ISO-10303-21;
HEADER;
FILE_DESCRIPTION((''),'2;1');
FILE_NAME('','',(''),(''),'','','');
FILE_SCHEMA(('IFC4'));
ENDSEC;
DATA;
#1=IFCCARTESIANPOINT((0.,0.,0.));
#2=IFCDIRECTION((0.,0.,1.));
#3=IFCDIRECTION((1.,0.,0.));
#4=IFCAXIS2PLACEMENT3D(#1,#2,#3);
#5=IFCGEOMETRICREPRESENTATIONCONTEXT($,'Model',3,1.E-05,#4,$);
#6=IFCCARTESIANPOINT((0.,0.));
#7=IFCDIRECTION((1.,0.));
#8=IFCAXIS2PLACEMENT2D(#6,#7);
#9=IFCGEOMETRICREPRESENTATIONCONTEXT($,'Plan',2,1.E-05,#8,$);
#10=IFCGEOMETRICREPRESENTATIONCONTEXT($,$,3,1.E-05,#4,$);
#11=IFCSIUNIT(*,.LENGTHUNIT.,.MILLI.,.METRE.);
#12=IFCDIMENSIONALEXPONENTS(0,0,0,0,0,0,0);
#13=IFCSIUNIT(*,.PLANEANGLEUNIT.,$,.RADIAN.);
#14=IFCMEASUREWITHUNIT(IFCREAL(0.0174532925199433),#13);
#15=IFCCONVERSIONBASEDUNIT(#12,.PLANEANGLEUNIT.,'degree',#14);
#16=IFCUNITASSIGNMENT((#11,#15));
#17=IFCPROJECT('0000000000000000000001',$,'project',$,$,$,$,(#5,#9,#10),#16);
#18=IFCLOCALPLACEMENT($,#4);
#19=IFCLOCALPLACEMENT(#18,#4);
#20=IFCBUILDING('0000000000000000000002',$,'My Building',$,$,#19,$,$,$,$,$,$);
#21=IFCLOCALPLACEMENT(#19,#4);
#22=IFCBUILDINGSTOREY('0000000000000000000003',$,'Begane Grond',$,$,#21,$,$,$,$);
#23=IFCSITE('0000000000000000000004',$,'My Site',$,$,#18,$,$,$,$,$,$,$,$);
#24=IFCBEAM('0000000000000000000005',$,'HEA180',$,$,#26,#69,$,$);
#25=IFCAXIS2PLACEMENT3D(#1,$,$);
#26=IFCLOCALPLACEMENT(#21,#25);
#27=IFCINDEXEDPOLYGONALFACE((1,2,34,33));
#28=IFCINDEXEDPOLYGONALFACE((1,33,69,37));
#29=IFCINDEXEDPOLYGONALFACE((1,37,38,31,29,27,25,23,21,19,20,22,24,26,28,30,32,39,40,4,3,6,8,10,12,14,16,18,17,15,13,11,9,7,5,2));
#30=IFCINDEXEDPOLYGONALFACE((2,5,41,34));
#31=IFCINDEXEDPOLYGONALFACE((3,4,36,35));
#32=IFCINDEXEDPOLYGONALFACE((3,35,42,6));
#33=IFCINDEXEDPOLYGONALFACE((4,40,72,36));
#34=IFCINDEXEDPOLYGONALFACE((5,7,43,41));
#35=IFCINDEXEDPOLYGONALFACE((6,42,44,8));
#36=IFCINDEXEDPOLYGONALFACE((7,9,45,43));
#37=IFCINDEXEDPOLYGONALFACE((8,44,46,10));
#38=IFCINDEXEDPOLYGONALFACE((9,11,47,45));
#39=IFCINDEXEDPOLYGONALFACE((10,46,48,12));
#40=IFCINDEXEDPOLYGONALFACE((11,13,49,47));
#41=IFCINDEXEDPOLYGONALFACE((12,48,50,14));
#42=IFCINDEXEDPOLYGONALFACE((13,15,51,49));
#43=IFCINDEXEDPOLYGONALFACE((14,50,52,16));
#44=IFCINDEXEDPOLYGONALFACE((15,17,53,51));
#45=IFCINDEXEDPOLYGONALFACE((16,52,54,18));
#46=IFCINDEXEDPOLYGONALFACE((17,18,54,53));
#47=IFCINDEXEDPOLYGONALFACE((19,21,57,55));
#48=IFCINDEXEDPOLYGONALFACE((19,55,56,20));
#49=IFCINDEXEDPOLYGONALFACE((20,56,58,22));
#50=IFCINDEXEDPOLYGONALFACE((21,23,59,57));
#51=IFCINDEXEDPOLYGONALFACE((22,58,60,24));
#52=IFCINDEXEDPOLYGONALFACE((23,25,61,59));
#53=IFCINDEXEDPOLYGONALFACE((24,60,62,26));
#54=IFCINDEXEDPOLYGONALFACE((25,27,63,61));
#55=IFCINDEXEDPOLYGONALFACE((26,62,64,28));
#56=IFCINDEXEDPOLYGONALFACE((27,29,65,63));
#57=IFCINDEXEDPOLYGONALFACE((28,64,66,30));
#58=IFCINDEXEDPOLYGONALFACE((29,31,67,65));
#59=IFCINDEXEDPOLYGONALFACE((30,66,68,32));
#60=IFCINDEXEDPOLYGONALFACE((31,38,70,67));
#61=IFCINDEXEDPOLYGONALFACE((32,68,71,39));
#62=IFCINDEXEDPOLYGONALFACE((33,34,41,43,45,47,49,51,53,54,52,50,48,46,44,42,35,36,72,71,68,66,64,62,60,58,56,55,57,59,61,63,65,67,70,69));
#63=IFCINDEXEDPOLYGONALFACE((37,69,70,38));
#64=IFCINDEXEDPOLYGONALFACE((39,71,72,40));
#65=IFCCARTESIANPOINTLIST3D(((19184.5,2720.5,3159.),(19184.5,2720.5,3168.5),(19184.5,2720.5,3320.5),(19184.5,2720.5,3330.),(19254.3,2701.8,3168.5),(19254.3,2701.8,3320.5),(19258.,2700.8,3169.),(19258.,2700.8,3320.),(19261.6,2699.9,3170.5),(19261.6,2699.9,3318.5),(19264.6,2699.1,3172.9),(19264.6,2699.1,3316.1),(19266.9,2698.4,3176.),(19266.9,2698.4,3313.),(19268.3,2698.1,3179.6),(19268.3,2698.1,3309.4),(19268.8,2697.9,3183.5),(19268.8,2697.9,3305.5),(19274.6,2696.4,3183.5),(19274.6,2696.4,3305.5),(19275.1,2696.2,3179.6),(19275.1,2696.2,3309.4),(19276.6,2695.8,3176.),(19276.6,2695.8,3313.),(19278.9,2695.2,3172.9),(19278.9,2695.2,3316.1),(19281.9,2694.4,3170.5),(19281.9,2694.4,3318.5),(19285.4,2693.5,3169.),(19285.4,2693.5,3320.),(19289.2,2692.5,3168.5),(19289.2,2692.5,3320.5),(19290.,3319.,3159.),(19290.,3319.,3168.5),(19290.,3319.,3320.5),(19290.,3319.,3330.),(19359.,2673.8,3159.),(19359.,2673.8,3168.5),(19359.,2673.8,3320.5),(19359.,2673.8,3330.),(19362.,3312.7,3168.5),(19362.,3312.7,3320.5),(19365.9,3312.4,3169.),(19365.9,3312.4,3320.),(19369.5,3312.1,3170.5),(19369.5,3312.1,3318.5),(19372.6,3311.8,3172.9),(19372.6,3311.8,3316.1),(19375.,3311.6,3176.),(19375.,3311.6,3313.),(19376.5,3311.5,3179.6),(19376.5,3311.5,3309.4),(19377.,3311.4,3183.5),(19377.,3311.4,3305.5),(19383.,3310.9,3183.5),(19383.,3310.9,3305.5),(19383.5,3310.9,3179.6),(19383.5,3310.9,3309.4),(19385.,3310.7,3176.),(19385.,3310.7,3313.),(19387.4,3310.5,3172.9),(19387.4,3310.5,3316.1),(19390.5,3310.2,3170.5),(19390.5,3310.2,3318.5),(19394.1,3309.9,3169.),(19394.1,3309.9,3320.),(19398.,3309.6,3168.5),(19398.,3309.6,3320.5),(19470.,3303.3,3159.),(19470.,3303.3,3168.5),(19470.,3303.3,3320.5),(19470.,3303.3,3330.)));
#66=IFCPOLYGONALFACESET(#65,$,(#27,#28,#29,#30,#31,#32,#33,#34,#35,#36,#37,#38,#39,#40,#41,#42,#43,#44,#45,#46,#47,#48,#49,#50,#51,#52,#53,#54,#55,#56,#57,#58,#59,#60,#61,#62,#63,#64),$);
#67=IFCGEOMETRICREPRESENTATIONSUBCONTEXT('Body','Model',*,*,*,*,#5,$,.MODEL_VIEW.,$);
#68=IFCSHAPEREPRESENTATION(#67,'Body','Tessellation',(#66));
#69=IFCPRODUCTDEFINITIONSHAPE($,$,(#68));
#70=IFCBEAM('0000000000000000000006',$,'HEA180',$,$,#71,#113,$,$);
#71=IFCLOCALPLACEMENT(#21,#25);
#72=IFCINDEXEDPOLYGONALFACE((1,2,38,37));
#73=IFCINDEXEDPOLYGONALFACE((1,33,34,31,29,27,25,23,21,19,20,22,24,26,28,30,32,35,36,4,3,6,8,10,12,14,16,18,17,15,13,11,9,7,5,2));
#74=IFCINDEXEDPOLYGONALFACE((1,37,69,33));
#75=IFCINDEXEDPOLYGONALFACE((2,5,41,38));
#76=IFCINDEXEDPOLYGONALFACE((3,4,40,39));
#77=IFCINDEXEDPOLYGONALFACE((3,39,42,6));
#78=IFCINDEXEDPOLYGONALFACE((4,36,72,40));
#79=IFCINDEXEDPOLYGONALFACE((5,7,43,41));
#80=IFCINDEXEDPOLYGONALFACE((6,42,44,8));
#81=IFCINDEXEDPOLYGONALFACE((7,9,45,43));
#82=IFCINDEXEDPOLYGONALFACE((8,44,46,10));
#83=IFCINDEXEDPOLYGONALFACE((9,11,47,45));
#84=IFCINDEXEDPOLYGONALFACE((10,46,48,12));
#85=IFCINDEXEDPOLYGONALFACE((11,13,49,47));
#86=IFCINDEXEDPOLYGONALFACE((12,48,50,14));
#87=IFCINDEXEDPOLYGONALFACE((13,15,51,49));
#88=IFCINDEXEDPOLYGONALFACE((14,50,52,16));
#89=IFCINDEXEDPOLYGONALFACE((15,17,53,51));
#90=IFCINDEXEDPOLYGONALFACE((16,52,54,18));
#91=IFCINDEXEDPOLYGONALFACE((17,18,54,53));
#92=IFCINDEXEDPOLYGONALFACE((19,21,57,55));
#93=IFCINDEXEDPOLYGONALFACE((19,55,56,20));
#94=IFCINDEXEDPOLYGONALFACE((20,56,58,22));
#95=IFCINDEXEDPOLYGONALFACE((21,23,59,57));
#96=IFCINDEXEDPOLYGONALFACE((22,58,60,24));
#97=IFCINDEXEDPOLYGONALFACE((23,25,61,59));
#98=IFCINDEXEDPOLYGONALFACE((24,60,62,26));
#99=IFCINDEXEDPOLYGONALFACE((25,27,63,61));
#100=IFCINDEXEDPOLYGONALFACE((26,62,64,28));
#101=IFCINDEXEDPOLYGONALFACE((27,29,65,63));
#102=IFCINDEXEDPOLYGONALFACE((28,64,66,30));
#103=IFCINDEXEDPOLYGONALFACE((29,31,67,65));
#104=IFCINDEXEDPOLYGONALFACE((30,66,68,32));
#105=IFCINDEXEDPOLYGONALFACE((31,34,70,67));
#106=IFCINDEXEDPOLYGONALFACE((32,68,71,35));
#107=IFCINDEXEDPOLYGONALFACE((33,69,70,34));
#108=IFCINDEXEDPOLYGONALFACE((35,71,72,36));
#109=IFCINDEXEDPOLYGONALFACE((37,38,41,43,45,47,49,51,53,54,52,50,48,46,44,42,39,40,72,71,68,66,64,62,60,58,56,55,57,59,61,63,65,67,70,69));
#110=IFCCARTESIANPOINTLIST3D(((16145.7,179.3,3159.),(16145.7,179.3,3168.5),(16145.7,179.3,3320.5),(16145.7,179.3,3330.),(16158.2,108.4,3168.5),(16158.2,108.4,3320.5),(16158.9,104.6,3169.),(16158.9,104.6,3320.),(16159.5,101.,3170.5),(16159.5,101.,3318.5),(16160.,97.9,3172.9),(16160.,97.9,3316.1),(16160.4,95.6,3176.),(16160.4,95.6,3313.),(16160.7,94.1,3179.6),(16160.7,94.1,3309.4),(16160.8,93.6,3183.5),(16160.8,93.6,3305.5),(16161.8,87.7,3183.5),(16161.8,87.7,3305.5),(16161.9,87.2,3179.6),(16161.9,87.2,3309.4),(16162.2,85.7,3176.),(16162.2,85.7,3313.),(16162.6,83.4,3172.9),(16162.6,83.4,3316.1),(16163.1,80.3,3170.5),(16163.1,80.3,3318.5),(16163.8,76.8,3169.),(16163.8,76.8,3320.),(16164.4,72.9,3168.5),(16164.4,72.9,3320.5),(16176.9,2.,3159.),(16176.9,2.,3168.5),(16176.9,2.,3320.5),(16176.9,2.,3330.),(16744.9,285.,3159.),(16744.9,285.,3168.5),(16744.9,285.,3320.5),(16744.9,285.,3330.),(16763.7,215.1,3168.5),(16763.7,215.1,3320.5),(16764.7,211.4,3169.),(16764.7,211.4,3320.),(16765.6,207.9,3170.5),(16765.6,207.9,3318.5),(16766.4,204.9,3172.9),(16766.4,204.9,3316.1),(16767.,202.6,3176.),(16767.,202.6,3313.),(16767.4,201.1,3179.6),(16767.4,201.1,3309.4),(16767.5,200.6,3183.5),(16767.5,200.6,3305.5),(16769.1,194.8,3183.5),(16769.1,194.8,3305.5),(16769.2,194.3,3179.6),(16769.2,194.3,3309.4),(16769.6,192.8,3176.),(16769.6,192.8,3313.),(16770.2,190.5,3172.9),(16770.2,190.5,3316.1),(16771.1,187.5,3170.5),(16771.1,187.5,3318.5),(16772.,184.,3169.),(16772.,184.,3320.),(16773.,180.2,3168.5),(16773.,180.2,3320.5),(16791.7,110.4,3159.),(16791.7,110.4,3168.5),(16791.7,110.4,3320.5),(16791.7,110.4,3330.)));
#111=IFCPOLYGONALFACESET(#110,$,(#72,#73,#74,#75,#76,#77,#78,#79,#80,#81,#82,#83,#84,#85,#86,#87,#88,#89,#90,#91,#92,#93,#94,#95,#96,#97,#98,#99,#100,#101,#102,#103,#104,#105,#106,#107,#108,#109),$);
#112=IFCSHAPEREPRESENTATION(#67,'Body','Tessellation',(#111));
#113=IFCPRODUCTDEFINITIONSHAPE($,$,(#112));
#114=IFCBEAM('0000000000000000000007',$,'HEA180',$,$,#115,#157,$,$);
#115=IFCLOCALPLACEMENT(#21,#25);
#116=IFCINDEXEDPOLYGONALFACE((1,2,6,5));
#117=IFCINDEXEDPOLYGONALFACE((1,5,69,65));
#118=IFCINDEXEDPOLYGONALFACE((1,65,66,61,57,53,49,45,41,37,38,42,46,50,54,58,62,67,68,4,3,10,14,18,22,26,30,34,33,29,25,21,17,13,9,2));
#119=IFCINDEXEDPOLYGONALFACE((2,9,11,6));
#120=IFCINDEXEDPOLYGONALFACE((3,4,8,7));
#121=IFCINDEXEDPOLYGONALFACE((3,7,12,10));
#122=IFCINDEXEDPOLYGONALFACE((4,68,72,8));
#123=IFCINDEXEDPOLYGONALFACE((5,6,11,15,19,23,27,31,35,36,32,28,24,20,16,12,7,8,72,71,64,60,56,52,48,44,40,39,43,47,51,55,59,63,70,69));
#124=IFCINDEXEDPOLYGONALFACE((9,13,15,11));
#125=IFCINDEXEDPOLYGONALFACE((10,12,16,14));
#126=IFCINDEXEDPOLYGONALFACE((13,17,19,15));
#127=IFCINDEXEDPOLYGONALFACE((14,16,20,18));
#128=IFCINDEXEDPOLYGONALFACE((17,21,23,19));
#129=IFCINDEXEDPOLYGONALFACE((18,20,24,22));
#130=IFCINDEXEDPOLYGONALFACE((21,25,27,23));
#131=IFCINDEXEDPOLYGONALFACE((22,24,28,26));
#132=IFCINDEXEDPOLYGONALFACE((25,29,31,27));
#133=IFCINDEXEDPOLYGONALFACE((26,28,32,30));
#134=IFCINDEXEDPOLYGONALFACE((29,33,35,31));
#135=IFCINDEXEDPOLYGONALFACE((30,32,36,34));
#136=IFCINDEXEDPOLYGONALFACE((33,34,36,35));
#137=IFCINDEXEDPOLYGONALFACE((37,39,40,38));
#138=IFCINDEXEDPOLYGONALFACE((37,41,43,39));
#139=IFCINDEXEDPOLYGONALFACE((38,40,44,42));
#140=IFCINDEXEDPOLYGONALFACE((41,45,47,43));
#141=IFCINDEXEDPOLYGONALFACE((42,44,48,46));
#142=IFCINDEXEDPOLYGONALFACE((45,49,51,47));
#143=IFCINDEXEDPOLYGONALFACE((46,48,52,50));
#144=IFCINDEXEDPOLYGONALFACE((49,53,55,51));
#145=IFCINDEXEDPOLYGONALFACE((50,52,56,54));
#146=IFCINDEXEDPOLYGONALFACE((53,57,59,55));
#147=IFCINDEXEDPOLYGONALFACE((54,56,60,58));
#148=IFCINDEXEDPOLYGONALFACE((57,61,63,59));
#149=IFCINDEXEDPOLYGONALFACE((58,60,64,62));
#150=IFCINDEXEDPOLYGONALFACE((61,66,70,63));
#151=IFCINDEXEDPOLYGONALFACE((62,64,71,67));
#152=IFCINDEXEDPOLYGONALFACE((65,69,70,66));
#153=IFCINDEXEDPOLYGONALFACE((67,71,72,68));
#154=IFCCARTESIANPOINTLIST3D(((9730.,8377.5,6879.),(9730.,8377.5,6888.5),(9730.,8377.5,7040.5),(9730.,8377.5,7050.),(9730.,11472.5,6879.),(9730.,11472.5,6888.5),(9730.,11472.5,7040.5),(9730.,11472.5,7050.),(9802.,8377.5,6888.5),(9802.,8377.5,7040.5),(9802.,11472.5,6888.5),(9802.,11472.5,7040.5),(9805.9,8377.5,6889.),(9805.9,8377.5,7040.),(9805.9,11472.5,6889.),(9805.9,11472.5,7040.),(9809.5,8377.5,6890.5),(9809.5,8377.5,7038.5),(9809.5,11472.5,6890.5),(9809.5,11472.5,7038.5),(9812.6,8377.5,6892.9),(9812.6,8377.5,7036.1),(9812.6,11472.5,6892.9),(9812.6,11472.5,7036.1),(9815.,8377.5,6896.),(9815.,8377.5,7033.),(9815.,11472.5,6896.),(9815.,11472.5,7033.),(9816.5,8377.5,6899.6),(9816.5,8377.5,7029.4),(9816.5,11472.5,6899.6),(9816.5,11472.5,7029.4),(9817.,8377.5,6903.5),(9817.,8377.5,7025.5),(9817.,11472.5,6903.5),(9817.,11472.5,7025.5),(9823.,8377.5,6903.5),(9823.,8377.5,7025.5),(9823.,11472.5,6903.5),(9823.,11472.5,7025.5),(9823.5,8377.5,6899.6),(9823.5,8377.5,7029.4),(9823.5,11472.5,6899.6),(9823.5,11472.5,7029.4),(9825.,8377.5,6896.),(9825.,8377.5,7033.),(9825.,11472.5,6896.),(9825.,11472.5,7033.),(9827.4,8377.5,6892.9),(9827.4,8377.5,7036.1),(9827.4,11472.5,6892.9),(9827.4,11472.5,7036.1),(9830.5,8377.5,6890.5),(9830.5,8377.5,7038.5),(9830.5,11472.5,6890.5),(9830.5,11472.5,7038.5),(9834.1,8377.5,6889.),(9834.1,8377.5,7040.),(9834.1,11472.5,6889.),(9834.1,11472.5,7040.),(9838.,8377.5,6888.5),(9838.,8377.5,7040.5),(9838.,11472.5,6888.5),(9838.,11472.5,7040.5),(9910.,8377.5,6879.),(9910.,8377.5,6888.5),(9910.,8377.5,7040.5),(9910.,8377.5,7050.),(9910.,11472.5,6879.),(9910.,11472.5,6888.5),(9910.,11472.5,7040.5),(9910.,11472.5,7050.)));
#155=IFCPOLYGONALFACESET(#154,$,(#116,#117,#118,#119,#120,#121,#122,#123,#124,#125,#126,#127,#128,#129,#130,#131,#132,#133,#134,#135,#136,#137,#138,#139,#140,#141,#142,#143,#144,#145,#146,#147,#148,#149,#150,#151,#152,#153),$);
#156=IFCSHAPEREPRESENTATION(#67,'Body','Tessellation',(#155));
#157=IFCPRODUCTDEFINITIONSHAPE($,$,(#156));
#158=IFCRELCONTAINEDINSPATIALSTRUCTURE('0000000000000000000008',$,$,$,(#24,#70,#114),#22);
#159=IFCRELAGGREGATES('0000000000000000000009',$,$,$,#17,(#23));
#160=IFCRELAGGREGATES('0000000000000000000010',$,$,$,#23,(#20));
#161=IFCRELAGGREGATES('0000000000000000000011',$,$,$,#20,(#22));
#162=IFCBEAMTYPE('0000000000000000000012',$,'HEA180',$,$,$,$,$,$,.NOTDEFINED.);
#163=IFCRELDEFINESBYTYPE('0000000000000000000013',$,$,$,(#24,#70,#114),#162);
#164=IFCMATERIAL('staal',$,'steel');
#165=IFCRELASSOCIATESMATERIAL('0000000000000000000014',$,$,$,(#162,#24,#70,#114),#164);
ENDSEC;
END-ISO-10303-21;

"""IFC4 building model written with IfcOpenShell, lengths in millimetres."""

from ifc_helpers import new_model, entity, si_unit, converted_unit, frame, origin_with_axes, origin_2d_with_axis, place, context, subcontext, project, spatial, i_section, extrude, clip, halfspace, material, material_profile, profile_set, profile_usage, type_object, element, save


model = new_model("IFC4")

# Units and contexts
model_context = context("Model", 3, precision=1e-05, world=origin_with_axes())
plan_context = context("Plan", 2, precision=1e-05, world=origin_2d_with_axis())
context_of_model = context(None, 3, precision=1e-05, world=origin_with_axes())
body_context = subcontext(model_context, "Body", "Model", "MODEL_VIEW")
ifc_project = project(units=[si_unit("LENGTHUNIT", "METRE", prefix="MILLI"), converted_unit("PLANEANGLEUNIT", "degree", entity("IfcReal", 0.0174532925199433), si_unit("PLANEANGLEUNIT", "RADIAN"), dimensions=[0, 0, 0, 0, 0, 0, 0])], contexts=[model_context, plan_context, context_of_model])

# Site, building, storey
site_placement = place(None, origin_with_axes())
site = spatial("IfcSite", under=ifc_project, at=site_placement, Name="My Site")
building_placement = place(site_placement, origin_with_axes())
building = spatial("IfcBuilding", under=site, at=building_placement, Name="My Building")
storey_placement = place(building_placement, origin_with_axes())
storey = spatial("IfcBuildingStorey", under=building, at=storey_placement, Name="Begane Grond")

# Shared definitions
ifc_material = material(Name="staal", Category="steel")

# Beams
ifc_material_profile_1 = material_profile(ifc_material, i_section(OverallWidth=180.0, OverallDepth=171.0, WebThickness=6.0, FlangeThickness=9.5, FilletRadius=15.0))
ifc_profile_set_1 = profile_set([ifc_material_profile_1], Name="HEA180")
beam_type_1 = type_object("IfcBeamType", Name="HEA180", PredefinedType="NOTDEFINED", material=ifc_profile_set_1)
ifc_profile_usage_1 = profile_usage(ifc_profile_set_1)
beam_1_placement = place(storey_placement, frame((19501.3, 3998.8, 3244.5), z_axis=(-0.173648, -0.984808, 0.0), x_axis=(0.984808, -0.173648, 0.0)))
element("IfcBeam", 1, at=beam_1_placement, inside=storey, type_object=beam_type_1, material=ifc_profile_usage_1, Name="HEA180", context=body_context, shape_type="Clipping", body=[
    clip(clip(extrude(i_section(OverallWidth=180.0, OverallDepth=171.0, WebThickness=6.0, FlangeThickness=9.5, FilletRadius=15.0), origin_with_axes(), (0.0, 0.0, 1.0), 2020.1), halfspace(frame((90.0, -3254.0, 690.4), z_axis=(-0.087188, 0.0, -0.996192), x_axis=(0.000001, 1.0, 0.0)), False)), halfspace(frame((90.0, -3254.0, 1329.6), z_axis=(-0.087089, 0.0, 0.996201), x_axis=(0.0, 1.0, 0.0)), False)),
])
ifc_profile_usage_2 = profile_usage(ifc_profile_set_1)
beam_2_placement = place(storey_placement, frame((17456.0, 319.0, 3244.5), z_axis=(-0.984808, -0.173648, 0.0), x_axis=(0.173648, -0.984808, 0.0)))
element("IfcBeam", 2, at=beam_2_placement, inside=storey, type_object=beam_type_1, material=ifc_profile_usage_2, Name="HEA180", context=body_context, shape_type="Clipping", body=[
    clip(extrude(i_section(OverallWidth=180.0, OverallDepth=171.0, WebThickness=6.0, FlangeThickness=9.5, FilletRadius=15.0), origin_with_axes(), (0.0, 0.0, 1.0), 1314.7), halfspace(frame((90.0, -3244.5, 690.4), z_axis=(-0.087167, 0.0, -0.996194), x_axis=(-0.000001, 1.0, 0.0)), False)),
])
ifc_profile_usage_3 = profile_usage(ifc_profile_set_1)
beam_3_placement = place(storey_placement, frame((9820.0, 11472.5, 6964.5), z_axis=(0.0, -1.0, 0.0), x_axis=(1.0, 0.0, 0.0)))
element("IfcBeam", 3, at=beam_3_placement, inside=storey, type_object=beam_type_1, material=ifc_profile_usage_3, Name="HEA180", context=body_context, shape_type="SweptSolid", body=[
    extrude(i_section(OverallWidth=180.0, OverallDepth=171.0, WebThickness=6.0, FlangeThickness=9.5, FilletRadius=15.0), origin_with_axes(), (0.0, 0.0, 1.0), 3095.0),
])

save(model, "model.ifc")
